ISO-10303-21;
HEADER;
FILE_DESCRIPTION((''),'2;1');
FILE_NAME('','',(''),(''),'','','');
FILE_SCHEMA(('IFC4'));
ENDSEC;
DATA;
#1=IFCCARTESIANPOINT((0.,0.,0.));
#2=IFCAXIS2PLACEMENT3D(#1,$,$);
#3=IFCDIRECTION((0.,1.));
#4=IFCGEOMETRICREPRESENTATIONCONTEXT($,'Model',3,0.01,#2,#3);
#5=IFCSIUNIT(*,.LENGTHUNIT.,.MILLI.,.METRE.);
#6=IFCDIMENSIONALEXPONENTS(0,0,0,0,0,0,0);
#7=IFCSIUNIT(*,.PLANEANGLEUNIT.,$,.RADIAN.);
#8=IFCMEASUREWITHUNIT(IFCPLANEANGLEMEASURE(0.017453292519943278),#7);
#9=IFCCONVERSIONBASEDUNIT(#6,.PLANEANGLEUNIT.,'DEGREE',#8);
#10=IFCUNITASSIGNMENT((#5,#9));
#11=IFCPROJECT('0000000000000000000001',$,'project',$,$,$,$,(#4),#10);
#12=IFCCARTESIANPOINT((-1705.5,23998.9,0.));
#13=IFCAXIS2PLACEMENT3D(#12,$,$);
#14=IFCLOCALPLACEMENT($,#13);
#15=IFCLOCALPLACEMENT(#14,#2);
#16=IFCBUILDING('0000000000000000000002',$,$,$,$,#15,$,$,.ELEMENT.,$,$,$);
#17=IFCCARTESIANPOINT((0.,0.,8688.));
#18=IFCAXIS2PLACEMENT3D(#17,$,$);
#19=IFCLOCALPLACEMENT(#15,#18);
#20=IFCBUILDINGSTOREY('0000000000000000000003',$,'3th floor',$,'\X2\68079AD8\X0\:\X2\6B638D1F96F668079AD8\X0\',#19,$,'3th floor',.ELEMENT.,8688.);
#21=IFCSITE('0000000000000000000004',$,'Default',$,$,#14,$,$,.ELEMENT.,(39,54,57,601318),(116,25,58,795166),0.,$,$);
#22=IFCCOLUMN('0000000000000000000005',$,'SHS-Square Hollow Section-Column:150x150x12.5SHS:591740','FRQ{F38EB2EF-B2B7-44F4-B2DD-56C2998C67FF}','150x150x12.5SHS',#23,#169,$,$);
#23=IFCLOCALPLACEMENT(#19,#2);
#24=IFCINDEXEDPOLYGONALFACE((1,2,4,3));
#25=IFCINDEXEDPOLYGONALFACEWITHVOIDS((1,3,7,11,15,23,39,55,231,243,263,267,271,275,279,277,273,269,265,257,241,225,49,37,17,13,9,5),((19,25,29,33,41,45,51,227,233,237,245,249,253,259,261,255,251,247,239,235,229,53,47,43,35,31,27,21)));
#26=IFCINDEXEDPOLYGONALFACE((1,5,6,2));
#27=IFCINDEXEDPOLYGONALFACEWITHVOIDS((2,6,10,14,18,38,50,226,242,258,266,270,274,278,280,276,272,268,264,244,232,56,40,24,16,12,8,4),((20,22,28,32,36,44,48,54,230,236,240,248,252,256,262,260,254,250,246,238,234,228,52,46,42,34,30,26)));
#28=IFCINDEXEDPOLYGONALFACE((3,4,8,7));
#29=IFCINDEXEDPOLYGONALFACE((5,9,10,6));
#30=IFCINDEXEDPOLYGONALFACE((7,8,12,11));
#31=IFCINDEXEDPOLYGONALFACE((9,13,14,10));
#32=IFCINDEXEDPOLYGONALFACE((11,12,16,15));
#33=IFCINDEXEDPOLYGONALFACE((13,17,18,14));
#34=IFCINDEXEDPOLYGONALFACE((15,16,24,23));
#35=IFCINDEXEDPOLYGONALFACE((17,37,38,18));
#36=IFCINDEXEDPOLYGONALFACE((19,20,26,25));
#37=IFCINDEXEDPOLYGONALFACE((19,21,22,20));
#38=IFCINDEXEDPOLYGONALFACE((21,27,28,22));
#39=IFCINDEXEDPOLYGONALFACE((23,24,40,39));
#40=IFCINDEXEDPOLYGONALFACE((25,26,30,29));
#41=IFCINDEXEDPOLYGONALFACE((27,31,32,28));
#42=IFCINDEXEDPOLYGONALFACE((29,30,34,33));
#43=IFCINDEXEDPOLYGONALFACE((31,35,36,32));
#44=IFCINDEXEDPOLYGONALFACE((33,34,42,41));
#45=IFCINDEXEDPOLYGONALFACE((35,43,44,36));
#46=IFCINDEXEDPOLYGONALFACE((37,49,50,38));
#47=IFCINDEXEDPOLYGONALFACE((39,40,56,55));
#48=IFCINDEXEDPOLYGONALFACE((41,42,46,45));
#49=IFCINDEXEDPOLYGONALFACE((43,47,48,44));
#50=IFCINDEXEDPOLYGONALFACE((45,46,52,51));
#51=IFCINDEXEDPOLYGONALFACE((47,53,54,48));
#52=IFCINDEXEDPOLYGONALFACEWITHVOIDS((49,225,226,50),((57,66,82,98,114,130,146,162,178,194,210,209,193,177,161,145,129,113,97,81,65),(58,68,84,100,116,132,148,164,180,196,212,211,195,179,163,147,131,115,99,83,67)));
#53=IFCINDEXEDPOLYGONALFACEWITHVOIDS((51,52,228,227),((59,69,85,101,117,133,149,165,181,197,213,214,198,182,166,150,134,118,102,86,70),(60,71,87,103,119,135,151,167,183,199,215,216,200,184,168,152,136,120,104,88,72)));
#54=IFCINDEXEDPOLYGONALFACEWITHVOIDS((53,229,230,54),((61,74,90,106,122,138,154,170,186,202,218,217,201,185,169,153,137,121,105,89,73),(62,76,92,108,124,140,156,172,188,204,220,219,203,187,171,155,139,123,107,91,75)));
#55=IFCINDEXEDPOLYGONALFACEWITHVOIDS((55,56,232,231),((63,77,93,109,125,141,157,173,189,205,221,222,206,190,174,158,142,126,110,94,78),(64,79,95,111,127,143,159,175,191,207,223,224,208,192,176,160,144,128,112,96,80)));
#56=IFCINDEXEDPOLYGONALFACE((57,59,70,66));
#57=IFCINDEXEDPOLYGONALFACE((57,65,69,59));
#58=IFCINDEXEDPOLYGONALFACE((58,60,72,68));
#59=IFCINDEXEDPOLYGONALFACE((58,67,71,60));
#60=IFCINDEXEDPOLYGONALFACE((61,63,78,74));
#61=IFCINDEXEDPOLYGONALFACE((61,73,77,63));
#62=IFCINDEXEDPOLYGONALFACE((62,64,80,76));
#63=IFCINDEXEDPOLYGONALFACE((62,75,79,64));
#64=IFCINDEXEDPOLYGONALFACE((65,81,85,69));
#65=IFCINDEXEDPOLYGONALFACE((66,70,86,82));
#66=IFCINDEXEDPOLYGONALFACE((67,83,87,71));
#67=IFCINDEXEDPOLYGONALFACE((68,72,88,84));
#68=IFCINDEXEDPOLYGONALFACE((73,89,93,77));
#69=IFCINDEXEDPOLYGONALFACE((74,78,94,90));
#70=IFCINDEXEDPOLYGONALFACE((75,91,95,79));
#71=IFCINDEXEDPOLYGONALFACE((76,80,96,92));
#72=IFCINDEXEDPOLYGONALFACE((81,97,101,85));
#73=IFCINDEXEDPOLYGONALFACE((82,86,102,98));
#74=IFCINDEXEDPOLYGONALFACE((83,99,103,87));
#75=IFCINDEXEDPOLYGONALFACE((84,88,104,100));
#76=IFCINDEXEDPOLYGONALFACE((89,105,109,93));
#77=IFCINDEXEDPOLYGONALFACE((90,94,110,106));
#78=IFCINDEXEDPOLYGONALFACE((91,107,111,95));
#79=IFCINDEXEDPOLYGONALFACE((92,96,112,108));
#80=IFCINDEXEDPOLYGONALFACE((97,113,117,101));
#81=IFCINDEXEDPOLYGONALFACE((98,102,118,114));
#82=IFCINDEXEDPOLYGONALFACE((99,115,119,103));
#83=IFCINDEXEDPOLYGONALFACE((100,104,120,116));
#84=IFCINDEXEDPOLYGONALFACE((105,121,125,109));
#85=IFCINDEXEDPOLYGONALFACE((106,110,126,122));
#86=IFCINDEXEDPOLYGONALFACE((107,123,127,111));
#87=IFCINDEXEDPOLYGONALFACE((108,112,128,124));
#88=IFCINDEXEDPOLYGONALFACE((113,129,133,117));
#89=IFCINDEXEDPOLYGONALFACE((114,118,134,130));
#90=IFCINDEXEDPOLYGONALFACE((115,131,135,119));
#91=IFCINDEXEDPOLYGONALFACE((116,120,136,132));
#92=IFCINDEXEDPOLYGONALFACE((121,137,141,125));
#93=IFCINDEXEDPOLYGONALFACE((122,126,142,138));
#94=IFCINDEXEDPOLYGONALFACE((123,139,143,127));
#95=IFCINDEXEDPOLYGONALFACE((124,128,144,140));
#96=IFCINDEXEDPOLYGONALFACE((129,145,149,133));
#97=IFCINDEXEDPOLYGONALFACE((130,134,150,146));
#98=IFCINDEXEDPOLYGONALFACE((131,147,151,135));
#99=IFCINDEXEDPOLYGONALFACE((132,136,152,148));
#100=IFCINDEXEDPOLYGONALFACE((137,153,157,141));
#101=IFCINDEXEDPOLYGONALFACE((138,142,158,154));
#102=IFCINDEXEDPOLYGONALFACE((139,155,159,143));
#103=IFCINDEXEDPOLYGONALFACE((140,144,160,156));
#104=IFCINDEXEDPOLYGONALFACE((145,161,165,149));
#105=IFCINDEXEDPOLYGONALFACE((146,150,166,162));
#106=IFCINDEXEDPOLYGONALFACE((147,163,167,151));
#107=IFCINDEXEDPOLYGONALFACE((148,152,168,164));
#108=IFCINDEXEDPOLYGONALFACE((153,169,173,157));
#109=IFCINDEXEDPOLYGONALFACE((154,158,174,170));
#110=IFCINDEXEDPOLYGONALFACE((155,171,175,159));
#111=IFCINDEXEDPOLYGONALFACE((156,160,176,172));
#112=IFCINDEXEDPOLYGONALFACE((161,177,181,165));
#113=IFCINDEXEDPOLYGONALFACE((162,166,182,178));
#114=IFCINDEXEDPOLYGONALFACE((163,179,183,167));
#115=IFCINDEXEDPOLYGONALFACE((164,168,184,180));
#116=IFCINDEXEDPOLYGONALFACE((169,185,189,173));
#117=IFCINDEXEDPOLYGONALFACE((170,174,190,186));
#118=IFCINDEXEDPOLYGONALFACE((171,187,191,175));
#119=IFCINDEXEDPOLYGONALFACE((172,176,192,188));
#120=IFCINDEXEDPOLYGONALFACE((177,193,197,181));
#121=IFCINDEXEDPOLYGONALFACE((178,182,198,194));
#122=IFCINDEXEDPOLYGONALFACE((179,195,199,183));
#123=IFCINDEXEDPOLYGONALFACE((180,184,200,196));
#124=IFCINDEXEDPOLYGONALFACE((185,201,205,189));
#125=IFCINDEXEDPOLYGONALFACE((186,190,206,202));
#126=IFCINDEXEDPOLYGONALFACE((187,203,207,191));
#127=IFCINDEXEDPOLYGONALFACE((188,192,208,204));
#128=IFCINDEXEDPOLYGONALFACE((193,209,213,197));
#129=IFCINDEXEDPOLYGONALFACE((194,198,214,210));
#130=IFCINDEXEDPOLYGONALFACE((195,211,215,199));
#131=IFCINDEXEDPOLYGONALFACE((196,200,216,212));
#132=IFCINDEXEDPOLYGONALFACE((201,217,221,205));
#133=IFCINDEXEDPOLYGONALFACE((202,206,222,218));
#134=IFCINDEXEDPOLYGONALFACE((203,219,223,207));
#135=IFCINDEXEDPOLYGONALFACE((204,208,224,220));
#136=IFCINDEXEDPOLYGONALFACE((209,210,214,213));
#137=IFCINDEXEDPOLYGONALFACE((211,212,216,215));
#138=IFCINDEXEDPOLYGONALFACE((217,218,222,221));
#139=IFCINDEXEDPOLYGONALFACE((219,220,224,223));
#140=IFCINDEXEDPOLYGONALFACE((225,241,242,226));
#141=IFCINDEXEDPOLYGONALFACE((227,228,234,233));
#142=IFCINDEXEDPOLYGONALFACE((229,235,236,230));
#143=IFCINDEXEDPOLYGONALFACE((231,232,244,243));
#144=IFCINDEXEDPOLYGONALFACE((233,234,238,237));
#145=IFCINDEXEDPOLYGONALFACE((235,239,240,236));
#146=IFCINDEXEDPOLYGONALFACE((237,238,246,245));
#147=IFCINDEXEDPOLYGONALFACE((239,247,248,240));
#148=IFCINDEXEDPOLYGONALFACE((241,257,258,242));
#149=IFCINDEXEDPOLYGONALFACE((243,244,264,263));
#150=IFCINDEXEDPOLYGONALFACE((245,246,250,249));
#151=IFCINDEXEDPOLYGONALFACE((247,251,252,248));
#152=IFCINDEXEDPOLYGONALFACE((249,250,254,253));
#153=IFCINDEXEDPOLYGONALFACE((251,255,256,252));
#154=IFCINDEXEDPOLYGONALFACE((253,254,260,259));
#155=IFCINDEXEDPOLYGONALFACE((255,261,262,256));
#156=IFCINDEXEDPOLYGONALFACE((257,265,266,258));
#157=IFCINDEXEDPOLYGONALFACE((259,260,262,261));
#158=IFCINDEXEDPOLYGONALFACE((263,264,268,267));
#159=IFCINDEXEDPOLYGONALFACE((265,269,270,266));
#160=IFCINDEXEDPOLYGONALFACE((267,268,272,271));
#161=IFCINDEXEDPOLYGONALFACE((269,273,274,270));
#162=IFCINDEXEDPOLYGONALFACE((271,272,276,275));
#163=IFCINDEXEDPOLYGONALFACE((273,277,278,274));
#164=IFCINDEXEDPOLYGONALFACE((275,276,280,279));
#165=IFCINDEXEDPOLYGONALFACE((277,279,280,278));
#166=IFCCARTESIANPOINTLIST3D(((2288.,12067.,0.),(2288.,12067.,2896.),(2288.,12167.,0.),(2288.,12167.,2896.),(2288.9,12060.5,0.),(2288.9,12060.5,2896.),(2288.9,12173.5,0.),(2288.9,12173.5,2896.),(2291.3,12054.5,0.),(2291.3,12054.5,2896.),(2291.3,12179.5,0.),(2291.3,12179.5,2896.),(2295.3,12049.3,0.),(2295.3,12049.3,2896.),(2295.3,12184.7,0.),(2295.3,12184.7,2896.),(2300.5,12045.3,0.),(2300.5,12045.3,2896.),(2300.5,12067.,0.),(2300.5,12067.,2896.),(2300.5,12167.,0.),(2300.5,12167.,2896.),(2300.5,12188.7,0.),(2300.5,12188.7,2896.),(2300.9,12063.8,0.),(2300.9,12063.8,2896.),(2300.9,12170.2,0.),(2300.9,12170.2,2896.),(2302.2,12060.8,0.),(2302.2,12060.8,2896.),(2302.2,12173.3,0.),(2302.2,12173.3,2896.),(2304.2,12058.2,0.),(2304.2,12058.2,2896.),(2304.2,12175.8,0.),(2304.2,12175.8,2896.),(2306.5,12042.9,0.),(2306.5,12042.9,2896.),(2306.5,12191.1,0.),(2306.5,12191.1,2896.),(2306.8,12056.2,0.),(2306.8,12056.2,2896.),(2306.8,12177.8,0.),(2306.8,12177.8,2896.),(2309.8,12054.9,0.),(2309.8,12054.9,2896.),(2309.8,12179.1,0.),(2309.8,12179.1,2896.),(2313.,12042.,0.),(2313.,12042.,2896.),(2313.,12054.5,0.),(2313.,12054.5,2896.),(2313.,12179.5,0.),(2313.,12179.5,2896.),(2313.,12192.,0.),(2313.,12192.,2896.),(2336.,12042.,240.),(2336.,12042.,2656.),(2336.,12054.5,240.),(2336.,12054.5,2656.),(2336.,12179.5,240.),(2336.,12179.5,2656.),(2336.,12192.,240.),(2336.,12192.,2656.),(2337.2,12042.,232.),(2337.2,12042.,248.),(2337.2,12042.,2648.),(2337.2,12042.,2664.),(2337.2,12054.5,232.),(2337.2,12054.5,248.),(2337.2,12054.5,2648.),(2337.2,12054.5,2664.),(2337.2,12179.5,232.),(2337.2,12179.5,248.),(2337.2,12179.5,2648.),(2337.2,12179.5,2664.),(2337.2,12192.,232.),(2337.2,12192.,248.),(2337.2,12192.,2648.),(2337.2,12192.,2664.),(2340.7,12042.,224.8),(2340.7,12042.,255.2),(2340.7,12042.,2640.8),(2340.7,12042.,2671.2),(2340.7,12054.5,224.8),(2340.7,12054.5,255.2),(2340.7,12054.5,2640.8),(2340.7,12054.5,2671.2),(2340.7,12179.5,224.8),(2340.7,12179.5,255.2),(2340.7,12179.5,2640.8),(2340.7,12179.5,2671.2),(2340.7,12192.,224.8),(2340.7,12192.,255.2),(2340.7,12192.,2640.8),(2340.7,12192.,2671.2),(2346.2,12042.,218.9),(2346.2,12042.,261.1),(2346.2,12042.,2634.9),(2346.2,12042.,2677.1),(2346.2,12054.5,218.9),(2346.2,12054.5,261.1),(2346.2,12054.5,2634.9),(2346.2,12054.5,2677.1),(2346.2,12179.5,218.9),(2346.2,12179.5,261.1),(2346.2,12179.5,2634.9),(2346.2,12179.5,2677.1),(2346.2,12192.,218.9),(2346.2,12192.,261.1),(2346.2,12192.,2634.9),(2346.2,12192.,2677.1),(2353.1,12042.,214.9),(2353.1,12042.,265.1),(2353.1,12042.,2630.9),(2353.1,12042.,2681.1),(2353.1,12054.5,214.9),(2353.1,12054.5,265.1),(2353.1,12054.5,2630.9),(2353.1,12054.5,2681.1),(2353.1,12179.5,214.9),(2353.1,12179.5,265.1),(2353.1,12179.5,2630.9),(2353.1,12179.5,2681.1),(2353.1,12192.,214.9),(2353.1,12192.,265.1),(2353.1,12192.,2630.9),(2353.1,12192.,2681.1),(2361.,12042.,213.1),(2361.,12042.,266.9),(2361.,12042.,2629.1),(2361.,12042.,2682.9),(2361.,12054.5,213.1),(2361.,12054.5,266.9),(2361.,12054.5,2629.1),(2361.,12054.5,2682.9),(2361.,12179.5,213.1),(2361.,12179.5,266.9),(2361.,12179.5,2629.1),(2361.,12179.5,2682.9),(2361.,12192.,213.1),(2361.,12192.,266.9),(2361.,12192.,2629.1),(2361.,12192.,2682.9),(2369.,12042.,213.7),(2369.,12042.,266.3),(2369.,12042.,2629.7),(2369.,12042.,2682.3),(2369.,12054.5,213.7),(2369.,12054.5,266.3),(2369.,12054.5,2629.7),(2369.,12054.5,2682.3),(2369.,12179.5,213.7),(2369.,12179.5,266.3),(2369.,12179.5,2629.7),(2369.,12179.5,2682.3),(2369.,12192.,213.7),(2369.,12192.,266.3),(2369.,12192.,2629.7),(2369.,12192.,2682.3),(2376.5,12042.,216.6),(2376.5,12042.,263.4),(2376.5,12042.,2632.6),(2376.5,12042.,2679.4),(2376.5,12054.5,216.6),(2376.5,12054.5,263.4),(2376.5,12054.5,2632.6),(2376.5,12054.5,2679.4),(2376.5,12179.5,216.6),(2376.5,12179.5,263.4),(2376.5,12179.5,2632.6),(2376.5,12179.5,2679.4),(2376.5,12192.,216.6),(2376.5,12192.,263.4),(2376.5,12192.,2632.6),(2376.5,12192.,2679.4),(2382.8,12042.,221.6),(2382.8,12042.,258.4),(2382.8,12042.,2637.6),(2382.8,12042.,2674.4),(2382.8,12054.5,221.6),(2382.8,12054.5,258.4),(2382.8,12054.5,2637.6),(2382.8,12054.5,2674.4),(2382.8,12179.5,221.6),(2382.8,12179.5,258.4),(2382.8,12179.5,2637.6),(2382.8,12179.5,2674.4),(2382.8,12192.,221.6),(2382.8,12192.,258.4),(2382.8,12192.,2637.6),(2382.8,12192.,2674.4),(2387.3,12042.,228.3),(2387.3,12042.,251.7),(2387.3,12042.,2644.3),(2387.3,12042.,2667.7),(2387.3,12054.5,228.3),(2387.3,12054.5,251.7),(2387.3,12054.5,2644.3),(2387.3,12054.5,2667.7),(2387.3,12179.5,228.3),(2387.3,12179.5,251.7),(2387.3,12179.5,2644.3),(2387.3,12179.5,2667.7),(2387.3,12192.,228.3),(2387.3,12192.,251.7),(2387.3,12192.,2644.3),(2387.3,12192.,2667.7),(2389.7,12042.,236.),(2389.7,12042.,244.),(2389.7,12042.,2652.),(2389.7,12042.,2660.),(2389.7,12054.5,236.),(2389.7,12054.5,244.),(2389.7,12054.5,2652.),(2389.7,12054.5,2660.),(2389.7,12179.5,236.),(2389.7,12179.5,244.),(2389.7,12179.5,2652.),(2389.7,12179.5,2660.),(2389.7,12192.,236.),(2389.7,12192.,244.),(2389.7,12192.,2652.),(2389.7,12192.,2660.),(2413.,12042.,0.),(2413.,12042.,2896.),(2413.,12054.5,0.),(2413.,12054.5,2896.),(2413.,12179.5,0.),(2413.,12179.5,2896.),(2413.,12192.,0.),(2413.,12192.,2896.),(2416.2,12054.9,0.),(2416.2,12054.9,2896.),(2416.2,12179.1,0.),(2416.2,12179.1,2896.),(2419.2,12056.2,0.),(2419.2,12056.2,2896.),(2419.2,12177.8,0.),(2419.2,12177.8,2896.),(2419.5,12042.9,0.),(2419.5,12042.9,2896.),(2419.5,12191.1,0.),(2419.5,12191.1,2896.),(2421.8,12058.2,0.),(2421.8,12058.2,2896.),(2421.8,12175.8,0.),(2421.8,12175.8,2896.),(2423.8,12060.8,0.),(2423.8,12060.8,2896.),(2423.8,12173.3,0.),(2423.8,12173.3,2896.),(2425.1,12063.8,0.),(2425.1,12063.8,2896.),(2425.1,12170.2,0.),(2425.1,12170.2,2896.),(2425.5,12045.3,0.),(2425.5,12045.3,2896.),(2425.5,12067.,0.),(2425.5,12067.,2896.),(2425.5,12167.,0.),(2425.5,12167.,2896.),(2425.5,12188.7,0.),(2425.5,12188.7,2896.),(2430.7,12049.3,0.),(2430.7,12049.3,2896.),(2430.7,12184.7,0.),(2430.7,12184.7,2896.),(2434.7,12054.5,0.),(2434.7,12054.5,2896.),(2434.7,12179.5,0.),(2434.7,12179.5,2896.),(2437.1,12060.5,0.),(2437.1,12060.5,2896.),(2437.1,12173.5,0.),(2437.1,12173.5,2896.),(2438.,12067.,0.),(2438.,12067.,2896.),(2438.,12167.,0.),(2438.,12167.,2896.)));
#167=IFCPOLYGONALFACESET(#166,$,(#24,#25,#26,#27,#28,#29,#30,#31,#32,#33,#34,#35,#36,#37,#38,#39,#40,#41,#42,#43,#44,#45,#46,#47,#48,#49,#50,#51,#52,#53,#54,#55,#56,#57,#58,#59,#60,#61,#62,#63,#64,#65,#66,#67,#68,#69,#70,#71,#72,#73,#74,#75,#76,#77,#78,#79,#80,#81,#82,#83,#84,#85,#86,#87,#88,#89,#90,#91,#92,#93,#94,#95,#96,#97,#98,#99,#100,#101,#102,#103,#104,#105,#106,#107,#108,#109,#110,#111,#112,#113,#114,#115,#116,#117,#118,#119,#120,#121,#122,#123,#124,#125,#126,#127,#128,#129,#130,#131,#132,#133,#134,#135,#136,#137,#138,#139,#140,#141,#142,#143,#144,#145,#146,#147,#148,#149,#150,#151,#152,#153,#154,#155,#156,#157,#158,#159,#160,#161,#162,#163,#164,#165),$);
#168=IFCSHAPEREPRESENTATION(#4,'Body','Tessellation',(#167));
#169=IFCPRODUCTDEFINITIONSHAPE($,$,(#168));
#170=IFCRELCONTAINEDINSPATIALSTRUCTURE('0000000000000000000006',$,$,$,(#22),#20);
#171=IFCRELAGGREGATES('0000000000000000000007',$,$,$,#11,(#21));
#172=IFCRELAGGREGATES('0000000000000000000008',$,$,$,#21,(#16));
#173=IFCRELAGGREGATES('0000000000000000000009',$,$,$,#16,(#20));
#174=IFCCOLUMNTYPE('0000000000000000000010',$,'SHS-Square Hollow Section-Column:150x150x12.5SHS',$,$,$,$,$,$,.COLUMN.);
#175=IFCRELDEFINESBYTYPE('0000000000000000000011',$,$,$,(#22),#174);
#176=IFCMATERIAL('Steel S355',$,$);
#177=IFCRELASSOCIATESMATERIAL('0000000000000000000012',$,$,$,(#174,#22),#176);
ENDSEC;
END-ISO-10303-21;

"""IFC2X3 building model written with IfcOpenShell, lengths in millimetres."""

from ifc_helpers import new_model, entity, si_unit, converted_unit, direction, frame, frame_2d, origin, origin_2d, place, context, project, spatial, circle_curve, hollow_rectangle, outline, extrude, material, type_object, element, save


model = new_model("IFC2X3")

# Units and contexts
model_context = context("Model", 3, precision=0.01, world=origin(), true_north=direction((0.0, 1.0)))
ifc_project = project(units=[si_unit("LENGTHUNIT", "METRE", prefix="MILLI"), converted_unit("PLANEANGLEUNIT", "DEGREE", entity("IfcPlaneAngleMeasure", 0.017453292519943278), si_unit("PLANEANGLEUNIT", "RADIAN"), dimensions=[0, 0, 0, 0, 0, 0, 0])], contexts=[model_context])

# Site, building, storey
site_placement = place(None, frame((-1705.5, 23998.9, 0.0)))
site = spatial("IfcSite", under=ifc_project, at=site_placement, Name="Default", CompositionType="ELEMENT", RefLatitude=(39, 54, 57, 601318), RefLongitude=(116, 25, 58, 795166), RefElevation=0.0)
building_placement = place(site_placement, origin())
building = spatial("IfcBuilding", under=site, at=building_placement, CompositionType="ELEMENT")
storey_placement = place(building_placement, frame((0.0, 0.0, 8688.0)))
storey = spatial("IfcBuildingStorey", under=building, at=storey_placement, Name="3th floor", ObjectType="标高:正负零标高", LongName="3th floor", CompositionType="ELEMENT", Elevation=8688.0)

# Shared definitions
ifc_material_1 = material(Name="Steel S355")

# Column, openings
column_type_1 = type_object("IfcColumnType", Name="SHS-Square Hollow Section-Column:150x150x12.5SHS", PredefinedType="COLUMN", material=ifc_material_1)
column_1_placement = place(storey_placement, frame((2363.0, 12117.0, 2896.0), z_axis=(0.0, 0.0, 1.0), x_axis=(0.0, -1.0, 0.0)))
column_1 = element("IfcColumn", 1, at=column_1_placement, inside=storey, type_object=column_type_1, material=ifc_material_1, Name="SHS-Square Hollow Section-Column:150x150x12.5SHS:591740", Description="FRQ{F38EB2EF-B2B7-44F4-B2DD-56C2998C67FF}", ObjectType="150x150x12.5SHS", context=model_context, shape_type="SweptSolid", body=[
    extrude(hollow_rectangle(XDim=150.0, YDim=150.0, WallThickness=12.5, InnerFilletRadius=12.5, OuterFilletRadius=25.0, at=origin_2d()), origin(), (0.0, 0.0, -1.0), 2896.0),
])
opening_1_placement = place(column_1_placement, frame((175.1, 0.0, 0.0), z_axis=(-1.0, 0.0, 0.0), x_axis=(0.0, -1.0, 0.0)))
element("IfcOpeningElement", 2, at=opening_1_placement, cuts=column_1, ObjectType="Opening", context=model_context, shape_type="SweptSolid", body=[
    extrude(outline(circle_curve(frame_2d((0.0, -240.0), x_axis=(1.0, 0.0)), 27.0)), origin(), (0.0, 0.0, 1.0), 350.2),
])
opening_2_placement = place(column_1_placement, frame((175.1, 0.0, -2896.0), z_axis=(-1.0, 0.0, 0.0), x_axis=(0.0, -1.0, 0.0)))
element("IfcOpeningElement", 3, at=opening_2_placement, cuts=column_1, ObjectType="Opening", context=model_context, shape_type="SweptSolid", body=[
    extrude(outline(circle_curve(frame_2d((0.0, 240.0), x_axis=(1.0, 0.0)), 27.0)), origin(), (0.0, 0.0, 1.0), 350.2),
])

save(model, "model.ifc")
